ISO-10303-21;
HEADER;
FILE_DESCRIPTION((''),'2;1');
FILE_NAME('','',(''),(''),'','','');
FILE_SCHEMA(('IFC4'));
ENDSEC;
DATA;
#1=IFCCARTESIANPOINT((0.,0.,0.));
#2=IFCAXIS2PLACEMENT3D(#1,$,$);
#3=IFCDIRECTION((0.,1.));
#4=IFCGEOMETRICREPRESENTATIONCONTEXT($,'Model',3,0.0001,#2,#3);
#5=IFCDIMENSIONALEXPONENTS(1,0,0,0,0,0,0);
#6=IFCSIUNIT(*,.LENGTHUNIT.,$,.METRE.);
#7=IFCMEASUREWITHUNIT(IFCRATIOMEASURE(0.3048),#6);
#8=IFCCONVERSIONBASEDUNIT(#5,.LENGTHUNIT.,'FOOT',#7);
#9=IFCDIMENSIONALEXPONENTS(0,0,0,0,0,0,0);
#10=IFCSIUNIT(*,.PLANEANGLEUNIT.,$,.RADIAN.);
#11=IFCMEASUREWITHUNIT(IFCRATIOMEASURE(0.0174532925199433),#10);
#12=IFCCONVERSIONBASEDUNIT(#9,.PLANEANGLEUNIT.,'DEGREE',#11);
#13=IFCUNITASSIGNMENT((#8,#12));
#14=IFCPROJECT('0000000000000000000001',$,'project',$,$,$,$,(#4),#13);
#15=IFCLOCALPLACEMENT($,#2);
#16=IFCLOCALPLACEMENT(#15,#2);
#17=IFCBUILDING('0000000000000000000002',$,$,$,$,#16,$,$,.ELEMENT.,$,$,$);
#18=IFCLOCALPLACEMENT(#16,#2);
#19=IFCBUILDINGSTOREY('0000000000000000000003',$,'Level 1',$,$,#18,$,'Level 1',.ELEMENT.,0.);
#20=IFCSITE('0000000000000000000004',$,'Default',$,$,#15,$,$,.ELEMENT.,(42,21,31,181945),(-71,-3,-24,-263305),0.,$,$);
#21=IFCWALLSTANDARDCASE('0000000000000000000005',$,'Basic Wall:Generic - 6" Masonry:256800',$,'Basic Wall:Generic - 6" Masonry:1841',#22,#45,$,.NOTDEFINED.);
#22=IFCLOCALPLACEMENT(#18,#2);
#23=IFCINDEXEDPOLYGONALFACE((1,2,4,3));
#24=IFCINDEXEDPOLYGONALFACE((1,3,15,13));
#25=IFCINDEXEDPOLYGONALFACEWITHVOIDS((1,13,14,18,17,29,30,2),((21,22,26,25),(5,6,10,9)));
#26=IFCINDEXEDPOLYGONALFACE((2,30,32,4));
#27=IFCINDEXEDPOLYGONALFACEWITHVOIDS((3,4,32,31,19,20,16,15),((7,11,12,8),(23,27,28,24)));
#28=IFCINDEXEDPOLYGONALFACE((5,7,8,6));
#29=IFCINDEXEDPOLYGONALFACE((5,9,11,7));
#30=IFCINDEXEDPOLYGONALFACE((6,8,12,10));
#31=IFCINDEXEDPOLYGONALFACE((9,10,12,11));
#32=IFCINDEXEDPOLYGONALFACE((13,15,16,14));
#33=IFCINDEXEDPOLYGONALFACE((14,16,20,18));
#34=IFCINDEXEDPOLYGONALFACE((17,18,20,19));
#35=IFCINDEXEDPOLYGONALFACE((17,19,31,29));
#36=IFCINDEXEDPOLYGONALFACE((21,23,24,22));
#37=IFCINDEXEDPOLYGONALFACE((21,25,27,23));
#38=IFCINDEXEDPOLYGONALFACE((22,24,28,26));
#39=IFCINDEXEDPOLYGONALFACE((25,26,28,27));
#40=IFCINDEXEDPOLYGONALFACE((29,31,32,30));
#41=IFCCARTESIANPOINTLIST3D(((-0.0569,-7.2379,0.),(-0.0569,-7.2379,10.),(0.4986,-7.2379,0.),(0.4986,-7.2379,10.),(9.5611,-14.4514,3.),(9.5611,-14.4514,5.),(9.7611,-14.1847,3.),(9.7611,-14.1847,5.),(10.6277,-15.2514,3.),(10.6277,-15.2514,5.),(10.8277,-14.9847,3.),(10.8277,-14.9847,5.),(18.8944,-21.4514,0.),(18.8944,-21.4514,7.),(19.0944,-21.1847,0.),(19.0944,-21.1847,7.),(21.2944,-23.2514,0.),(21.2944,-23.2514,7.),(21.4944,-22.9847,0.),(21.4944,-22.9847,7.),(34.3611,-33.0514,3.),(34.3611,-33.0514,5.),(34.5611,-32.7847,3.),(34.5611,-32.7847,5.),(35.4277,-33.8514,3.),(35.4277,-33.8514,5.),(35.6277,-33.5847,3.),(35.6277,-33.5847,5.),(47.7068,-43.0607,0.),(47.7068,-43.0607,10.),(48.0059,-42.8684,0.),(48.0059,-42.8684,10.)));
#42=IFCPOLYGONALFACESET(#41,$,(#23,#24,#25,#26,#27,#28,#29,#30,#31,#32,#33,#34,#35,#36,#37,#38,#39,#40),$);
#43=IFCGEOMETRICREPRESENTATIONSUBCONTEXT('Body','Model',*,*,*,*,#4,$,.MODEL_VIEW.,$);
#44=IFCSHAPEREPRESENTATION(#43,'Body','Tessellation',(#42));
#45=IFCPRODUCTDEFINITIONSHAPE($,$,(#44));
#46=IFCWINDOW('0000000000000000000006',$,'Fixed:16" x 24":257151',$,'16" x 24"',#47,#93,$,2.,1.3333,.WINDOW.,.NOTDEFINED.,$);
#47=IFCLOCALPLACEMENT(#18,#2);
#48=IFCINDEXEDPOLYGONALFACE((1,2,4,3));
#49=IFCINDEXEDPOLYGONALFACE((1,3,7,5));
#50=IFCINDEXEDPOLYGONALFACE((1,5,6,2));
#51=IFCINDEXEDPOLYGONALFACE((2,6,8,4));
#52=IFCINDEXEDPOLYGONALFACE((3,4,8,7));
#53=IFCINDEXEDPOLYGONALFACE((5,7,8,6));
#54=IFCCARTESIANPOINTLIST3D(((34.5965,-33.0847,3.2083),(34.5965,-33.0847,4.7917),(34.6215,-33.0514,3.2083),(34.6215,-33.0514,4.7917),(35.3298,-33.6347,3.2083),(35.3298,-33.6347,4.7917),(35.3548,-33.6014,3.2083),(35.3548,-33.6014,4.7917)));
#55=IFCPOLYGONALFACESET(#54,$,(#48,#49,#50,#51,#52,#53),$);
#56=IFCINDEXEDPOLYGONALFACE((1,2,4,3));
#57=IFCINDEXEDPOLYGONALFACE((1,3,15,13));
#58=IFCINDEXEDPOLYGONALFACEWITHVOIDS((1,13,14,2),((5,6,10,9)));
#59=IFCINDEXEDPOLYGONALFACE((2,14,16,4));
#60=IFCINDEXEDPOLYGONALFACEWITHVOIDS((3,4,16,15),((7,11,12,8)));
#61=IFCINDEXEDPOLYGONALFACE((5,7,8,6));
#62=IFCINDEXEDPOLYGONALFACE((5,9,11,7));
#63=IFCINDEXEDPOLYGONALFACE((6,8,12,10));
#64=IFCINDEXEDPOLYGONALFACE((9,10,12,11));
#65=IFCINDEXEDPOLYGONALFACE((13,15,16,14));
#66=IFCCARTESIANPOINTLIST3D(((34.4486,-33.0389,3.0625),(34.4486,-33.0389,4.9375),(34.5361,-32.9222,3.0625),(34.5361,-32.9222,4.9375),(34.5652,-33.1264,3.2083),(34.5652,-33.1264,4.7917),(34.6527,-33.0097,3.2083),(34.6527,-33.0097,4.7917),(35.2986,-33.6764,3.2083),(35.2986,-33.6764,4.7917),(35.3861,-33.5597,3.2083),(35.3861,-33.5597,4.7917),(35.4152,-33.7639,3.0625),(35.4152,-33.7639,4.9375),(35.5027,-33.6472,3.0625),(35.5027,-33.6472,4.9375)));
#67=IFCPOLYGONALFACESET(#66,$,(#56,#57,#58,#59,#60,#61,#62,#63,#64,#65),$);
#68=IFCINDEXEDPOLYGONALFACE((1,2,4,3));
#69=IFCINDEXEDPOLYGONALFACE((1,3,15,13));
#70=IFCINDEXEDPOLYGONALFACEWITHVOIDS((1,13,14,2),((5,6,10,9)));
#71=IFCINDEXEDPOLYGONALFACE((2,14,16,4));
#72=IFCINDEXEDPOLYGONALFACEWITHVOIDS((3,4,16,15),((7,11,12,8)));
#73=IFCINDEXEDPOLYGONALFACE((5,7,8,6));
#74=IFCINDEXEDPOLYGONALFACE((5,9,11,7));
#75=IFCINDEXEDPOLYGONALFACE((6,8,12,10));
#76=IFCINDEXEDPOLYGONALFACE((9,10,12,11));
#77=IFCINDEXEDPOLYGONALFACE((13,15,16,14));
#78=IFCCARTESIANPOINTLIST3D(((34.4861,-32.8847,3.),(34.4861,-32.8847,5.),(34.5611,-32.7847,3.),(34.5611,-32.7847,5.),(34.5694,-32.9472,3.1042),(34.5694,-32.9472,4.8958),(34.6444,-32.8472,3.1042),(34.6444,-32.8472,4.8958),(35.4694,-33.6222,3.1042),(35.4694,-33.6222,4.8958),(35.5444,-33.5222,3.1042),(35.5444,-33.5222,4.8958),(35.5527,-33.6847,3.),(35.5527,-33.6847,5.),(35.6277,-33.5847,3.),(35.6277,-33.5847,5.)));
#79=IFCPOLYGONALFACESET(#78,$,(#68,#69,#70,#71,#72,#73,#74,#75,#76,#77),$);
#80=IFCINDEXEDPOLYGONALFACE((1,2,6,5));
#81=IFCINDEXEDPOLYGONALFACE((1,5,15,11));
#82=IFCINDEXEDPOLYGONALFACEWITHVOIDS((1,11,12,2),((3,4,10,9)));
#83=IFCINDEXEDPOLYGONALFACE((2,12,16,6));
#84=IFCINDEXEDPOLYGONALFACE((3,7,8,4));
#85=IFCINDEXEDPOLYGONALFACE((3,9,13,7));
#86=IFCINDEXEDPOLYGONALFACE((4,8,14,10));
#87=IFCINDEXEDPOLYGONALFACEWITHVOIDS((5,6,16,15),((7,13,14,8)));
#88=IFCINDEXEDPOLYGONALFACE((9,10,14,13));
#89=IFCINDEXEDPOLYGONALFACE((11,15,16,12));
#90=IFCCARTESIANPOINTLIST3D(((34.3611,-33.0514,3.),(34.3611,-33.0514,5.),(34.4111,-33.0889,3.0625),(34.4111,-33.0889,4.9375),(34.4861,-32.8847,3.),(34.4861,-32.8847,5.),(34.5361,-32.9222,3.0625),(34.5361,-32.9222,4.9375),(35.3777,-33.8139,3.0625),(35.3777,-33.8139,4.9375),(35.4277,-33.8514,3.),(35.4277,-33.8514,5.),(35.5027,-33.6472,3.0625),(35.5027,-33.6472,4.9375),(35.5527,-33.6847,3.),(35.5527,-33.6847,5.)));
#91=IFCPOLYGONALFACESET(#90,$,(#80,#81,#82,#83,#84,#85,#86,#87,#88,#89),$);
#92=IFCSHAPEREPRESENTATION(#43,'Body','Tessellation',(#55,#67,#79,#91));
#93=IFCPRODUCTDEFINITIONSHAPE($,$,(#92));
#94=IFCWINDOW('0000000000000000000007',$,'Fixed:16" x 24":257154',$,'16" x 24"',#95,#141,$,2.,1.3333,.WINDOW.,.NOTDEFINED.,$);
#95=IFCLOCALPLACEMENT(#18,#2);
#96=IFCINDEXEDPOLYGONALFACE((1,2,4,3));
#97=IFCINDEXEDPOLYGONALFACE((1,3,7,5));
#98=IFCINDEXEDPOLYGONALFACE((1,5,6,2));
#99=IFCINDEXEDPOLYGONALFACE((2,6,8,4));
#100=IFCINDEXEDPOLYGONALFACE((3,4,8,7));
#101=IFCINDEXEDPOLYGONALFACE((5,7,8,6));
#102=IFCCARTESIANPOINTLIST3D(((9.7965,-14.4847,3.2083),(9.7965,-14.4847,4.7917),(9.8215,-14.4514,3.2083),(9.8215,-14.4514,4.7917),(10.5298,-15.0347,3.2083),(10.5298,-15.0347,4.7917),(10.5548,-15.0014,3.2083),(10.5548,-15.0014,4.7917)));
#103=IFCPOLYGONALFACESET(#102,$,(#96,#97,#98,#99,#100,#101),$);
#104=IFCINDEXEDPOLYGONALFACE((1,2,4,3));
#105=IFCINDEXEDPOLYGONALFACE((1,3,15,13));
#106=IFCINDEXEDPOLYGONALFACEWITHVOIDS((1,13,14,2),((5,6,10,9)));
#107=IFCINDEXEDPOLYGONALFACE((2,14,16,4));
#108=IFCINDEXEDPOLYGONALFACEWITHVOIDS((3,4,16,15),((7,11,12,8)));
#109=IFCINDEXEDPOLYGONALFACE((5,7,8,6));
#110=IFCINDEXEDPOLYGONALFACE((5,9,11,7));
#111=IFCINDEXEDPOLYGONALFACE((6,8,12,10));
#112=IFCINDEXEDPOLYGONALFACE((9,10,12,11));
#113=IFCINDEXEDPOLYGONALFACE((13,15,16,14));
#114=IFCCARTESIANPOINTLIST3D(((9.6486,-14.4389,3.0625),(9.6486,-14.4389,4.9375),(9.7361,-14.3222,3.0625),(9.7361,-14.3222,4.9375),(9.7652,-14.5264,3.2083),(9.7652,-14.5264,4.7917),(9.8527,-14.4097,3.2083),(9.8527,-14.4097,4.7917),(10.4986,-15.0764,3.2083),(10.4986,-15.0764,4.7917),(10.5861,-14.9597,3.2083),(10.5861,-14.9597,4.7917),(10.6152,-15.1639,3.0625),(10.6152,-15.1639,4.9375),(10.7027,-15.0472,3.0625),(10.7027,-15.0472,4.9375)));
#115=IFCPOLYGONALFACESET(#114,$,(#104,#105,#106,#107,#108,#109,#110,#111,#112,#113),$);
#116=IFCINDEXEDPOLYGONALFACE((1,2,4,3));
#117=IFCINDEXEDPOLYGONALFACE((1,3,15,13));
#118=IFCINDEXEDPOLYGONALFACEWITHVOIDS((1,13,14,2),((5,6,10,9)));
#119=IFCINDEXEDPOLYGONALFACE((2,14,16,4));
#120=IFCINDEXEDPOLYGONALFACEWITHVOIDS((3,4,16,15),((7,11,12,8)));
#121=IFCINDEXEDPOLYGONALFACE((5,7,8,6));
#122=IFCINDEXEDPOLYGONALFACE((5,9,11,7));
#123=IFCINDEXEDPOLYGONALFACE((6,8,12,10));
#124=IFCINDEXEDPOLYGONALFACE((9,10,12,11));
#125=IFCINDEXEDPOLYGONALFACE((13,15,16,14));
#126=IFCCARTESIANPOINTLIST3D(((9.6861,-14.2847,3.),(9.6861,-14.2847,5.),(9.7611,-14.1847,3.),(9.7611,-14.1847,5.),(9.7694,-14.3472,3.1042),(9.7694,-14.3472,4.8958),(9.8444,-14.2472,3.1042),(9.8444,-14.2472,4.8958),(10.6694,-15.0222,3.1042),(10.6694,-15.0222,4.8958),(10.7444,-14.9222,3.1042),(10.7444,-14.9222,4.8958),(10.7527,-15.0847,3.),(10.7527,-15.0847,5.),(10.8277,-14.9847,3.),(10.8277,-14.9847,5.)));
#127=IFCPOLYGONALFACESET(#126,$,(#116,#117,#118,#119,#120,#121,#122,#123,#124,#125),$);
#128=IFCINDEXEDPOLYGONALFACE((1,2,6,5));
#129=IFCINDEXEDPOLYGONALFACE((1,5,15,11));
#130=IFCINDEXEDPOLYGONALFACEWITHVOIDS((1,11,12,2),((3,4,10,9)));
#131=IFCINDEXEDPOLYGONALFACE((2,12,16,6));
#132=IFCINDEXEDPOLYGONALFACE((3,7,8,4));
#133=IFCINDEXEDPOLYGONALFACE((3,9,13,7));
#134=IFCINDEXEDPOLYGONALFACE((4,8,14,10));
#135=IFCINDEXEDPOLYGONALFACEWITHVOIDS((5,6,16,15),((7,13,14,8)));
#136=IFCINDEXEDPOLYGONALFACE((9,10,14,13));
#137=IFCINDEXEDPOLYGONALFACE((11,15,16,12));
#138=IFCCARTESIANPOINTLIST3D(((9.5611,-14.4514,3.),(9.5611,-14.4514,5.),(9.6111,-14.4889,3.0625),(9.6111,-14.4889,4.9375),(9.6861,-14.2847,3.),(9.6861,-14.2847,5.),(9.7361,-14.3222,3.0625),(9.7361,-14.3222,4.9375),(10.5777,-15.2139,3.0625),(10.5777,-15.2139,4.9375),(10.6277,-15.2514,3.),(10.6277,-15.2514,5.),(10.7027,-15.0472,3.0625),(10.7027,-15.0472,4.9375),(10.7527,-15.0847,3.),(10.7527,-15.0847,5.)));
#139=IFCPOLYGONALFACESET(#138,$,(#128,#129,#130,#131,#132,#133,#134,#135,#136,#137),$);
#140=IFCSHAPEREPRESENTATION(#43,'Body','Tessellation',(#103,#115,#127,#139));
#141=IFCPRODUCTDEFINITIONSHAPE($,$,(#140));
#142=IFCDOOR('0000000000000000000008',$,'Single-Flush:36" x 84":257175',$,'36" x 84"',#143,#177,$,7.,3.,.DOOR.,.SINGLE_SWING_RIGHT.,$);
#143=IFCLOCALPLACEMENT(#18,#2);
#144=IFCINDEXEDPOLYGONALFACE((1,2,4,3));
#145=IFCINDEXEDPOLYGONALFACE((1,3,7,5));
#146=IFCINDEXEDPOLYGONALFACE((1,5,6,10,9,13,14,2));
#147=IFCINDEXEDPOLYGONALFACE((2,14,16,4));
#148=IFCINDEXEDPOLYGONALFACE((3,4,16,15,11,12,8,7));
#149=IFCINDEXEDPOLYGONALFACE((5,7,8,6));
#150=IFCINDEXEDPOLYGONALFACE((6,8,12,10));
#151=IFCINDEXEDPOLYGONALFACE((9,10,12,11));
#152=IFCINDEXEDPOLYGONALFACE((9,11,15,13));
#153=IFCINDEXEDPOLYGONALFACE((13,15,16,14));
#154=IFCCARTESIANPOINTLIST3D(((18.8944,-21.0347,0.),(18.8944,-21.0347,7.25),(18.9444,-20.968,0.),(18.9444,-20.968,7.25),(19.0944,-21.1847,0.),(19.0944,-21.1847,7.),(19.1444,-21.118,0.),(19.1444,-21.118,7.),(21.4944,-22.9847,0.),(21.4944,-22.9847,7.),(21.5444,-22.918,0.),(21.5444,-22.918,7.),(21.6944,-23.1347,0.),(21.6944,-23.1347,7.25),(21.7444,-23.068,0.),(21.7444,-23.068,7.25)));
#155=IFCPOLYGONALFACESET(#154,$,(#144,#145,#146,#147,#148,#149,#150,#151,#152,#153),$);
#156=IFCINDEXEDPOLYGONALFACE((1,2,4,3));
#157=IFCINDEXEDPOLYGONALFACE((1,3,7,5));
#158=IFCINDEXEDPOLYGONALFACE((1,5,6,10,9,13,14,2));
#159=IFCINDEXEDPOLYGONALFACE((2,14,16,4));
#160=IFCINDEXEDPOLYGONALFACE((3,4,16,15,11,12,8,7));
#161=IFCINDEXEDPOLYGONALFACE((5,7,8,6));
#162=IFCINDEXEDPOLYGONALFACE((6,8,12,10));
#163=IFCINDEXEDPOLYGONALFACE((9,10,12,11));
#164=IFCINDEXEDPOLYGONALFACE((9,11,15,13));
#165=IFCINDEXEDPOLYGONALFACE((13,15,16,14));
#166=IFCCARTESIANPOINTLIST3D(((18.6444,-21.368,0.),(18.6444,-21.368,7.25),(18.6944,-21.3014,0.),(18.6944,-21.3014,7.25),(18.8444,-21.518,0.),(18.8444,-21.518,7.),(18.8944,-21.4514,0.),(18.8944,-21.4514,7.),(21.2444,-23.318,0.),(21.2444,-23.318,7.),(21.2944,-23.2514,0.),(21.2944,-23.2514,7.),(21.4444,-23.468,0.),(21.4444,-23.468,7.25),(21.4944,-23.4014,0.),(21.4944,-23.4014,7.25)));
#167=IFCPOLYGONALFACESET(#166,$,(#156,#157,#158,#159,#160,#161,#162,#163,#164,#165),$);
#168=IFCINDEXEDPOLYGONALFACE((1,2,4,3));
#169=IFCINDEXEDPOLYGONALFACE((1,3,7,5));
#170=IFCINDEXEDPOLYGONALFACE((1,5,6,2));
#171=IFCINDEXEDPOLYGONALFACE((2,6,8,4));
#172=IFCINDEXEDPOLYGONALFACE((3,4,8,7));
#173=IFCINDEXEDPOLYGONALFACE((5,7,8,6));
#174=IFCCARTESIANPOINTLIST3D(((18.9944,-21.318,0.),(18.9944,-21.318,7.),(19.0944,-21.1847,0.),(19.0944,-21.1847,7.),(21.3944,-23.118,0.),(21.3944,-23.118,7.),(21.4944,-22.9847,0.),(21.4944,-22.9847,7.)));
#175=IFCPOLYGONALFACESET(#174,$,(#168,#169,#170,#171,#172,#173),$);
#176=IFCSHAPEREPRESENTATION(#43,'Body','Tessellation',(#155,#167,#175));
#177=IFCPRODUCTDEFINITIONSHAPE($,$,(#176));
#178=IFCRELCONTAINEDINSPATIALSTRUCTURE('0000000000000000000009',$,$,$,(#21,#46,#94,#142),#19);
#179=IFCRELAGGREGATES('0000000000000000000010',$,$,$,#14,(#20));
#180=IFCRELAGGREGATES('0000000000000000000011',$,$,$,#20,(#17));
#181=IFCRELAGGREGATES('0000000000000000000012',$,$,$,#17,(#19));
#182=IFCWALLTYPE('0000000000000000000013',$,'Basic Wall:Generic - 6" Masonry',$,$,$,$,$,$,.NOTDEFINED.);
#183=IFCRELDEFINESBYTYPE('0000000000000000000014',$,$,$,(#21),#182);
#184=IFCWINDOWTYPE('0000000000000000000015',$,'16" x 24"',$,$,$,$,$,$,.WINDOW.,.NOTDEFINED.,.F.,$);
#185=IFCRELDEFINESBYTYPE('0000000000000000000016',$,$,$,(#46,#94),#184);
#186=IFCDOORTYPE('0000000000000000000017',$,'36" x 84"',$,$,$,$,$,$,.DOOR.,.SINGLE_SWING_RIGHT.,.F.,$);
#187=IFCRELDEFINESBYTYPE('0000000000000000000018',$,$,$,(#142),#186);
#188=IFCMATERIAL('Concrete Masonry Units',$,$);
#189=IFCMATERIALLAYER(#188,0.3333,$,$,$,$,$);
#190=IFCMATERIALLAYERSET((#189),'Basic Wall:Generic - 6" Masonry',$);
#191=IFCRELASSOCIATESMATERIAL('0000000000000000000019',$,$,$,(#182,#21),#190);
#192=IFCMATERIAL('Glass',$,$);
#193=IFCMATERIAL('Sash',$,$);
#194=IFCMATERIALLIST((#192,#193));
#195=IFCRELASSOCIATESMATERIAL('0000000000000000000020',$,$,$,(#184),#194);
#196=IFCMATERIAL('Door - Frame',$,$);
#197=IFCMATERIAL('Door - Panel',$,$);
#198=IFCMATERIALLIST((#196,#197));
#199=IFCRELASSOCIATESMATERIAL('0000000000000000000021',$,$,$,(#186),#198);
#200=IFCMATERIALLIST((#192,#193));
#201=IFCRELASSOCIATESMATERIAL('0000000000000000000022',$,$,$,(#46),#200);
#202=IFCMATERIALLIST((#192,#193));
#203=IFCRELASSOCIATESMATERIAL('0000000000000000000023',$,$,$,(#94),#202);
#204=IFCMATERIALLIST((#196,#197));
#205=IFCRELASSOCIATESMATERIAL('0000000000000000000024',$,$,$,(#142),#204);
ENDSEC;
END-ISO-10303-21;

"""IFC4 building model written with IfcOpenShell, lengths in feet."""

from ifc_helpers import new_model, entity, si_unit, converted_unit, direction, frame, frame_2d, origin, origin_2d_with_axis, place, context, subcontext, project, spatial, polyline, rectangle, outline, extrude, source, transform, mapped, material, material_list, layer, layer_set, layer_usage, type_object, type_shapes, element, fill, save


model = new_model("IFC4")

# Units and contexts
model_context = context("Model", 3, precision=0.0001, world=origin(), true_north=direction((0.0, 1.0)))
body_context = subcontext(model_context, "Body", "Model", "MODEL_VIEW")
ifc_project = project(units=[converted_unit("LENGTHUNIT", "FOOT", entity("IfcRatioMeasure", 0.3048), si_unit("LENGTHUNIT", "METRE"), dimensions=[1, 0, 0, 0, 0, 0, 0]), converted_unit("PLANEANGLEUNIT", "DEGREE", entity("IfcRatioMeasure", 0.0174532925199433), si_unit("PLANEANGLEUNIT", "RADIAN"), dimensions=[0, 0, 0, 0, 0, 0, 0])], contexts=[model_context])

# Site, building, storey
site_placement = place(None, origin())
site = spatial("IfcSite", under=ifc_project, at=site_placement, Name="Default", CompositionType="ELEMENT", RefLatitude=(42, 21, 31, 181945), RefLongitude=(-71, -3, -24, -263305), RefElevation=0.0)
building_placement = place(site_placement, origin())
building = spatial("IfcBuilding", under=site, at=building_placement, CompositionType="ELEMENT")
storey_placement = place(building_placement, origin())
storey = spatial("IfcBuildingStorey", under=building, at=storey_placement, Name="Level 1", LongName="Level 1", CompositionType="ELEMENT", Elevation=0.0)

# Shared definitions
ifc_material_1 = material(Name="Concrete Masonry Units")
ifc_layer = layer(ifc_material_1, 0.3333)
ifc_layer_set = layer_set([ifc_layer], Name="Basic Wall:Generic - 6\" Masonry")
wall_type = type_object("IfcWallType", Name="Basic Wall:Generic - 6\" Masonry", PredefinedType="NOTDEFINED", material=ifc_layer_set)
ifc_material_2 = material(Name="Glass")
ifc_material_3 = material(Name="Sash")
ifc_material_list_1 = material_list([ifc_material_2, ifc_material_3])
window_type = type_object("IfcWindowType", Name="16\" x 24\"", ParameterTakesPrecedence=False, PartitioningType="NOTDEFINED", PredefinedType="WINDOW", material=ifc_material_list_1)
shared_shape_1 = source(origin(), body_context, "Body", "SweptSolid", [
    extrude(rectangle(XDim=0.0417, YDim=0.9167, at=origin_2d_with_axis()), frame((0.6667, 0.1979, 0.2083), z_axis=(0.0, 0.0, 1.0), x_axis=(0.0, 1.0, 0.0)), (0.0, 0.0, 1.0), 1.5833),
    extrude(outline(polyline([(-0.6042, -0.9375), (0.6042, -0.9375), (0.6042, 0.9375), (-0.6042, 0.9375), (-0.6042, -0.9375)]), holes=[polyline([(-0.4583, -0.7917), (-0.4583, 0.7917), (0.4583, 0.7917), (0.4583, -0.7917), (-0.4583, -0.7917)])]), frame((0.6667, 0.125, 1.0), z_axis=(0.0, 1.0, 0.0), x_axis=(1.0, 0.0, 0.0)), (0.0, 0.0, 1.0), 0.1458),
    extrude(outline(polyline([(-0.6667, -1.0), (0.6667, -1.0), (0.6667, 1.0), (-0.6667, 1.0), (-0.6667, -1.0)]), holes=[polyline([(-0.5625, -0.8958), (-0.5625, 0.8958), (0.5625, 0.8958), (0.5625, -0.8958), (-0.5625, -0.8958)])]), frame((0.6667, 0.0, 1.0), z_axis=(0.0, 1.0, 0.0), x_axis=(1.0, 0.0, 0.0)), (0.0, 0.0, 1.0), 0.125),
    extrude(outline(polyline([(-1.0, -0.6667), (1.0, -0.6667), (1.0, 0.6667), (-1.0, 0.6667), (-1.0, -0.6667)]), holes=[polyline([(-0.9375, -0.6042), (-0.9375, 0.6042), (0.9375, 0.6042), (0.9375, -0.6042), (-0.9375, -0.6042)])]), frame((0.6667, 0.125, 1.0), z_axis=(0.0, 1.0, 0.0), x_axis=(0.0, 0.0, -1.0)), (0.0, 0.0, 1.0), 0.2083),
])
type_shapes(window_type, [shared_shape_1])
ifc_material_4 = material(Name="Door - Frame")
ifc_material_5 = material(Name="Door - Panel")
ifc_material_list_2 = material_list([ifc_material_4, ifc_material_5])
door_type = type_object("IfcDoorType", Name="36\" x 84\"", OperationType="SINGLE_SWING_RIGHT", ParameterTakesPrecedence=False, PredefinedType="DOOR", material=ifc_material_list_2)
shared_shape_2 = source(origin(), body_context, "Body", "SweptSolid", [
    extrude(outline(polyline([(-1.75, -3.6875), (1.75, -3.6875), (1.75, 3.5625), (1.5, 3.5625), (1.5, -3.4375), (-1.5, -3.4375), (-1.5, 3.5625), (-1.75, 3.5625), (-1.75, -3.6875)])), frame((1.5, 0.3333, 3.5625), z_axis=(0.0, 1.0, 0.0), x_axis=(1.0, 0.0, 0.0)), (0.0, 0.0, 1.0), 0.0833),
    extrude(outline(polyline([(-3.6875, -1.75), (3.5625, -1.75), (3.5625, -1.5), (-3.4375, -1.5), (-3.4375, 1.5), (3.5625, 1.5), (3.5625, 1.75), (-3.6875, 1.75), (-3.6875, -1.75)])), frame((1.5, -0.0833, 3.5625), z_axis=(0.0, 1.0, 0.0), x_axis=(0.0, 0.0, -1.0)), (0.0, 0.0, 1.0), 0.0833),
    extrude(rectangle(XDim=0.1667, YDim=3.0, at=frame_2d((0.0, 0.0), x_axis=(1.0, 0.0))), frame((1.5, 0.25, 0.0), z_axis=(0.0, 0.0, 1.0), x_axis=(0.0, 1.0, 0.0)), (0.0, 0.0, 1.0), 7.0),
])
type_shapes(door_type, [shared_shape_2])

# Wall, openings, windows, door
ifc_layer_usage_1 = layer_usage(ifc_layer_set, "AXIS2", "NEGATIVE", 0.1667)
wall_1_placement = place(storey_placement, frame((47.9059, -43.0017, 0.0), z_axis=(0.0, 0.0, 1.0), x_axis=(-0.8, 0.6, 0.0)))
wall_1 = element("IfcWallStandardCase", 1, at=wall_1_placement, inside=storey, type_object=wall_type, material=ifc_layer_usage_1, Name="Basic Wall:Generic - 6\" Masonry:256800", ObjectType="Basic Wall:Generic - 6\" Masonry:1841", PredefinedType="NOTDEFINED", context=body_context, shape_type="SweptSolid", body=[
    extrude(outline(polyline([(0.0, -0.1667), (59.3842, -0.1667), (59.8286, 0.1667), (0.1239, 0.1667), (0.0, -0.1667)])), origin(), (0.0, 0.0, 1.0), 10.0),
])
opening_1_placement = place(wall_1_placement, frame((36.1394, 0.1667, 0.0)))
opening_1 = element("IfcOpeningElement", 2, at=opening_1_placement, cuts=wall_1, ObjectType="Opening", PredefinedType="OPENING", context=body_context, shape_type="SweptSolid", body=[
    extrude(rectangle(XDim=3.0, YDim=7.0, at=frame_2d((3.5, 1.5), x_axis=(0.0, 1.0))), frame((0.0, 0.0, 0.0), z_axis=(0.0, -1.0, 0.0), x_axis=(0.0, 0.0, 1.0)), (0.0, 0.0, 1.0), 0.3333),
])
opening_2_placement = place(wall_1_placement, frame((15.4728, -0.1667, 3.0)))
opening_2 = element("IfcOpeningElement", 3, at=opening_2_placement, cuts=wall_1, ObjectType="Opening", PredefinedType="OPENING", context=body_context, shape_type="SweptSolid", body=[
    extrude(rectangle(XDim=2.0, YDim=1.3333, at=frame_2d((1.0, 0.6667), x_axis=(-1.0, 0.0))), frame((0.0, 0.0, 0.0), z_axis=(0.0, 1.0, 0.0), x_axis=(0.0, 0.0, 1.0)), (0.0, 0.0, 1.0), 0.3333),
])
opening_3_placement = place(wall_1_placement, frame((46.4728, -0.1667, 3.0)))
opening_3 = element("IfcOpeningElement", 4, at=opening_3_placement, cuts=wall_1, ObjectType="Opening", PredefinedType="OPENING", context=body_context, shape_type="SweptSolid", body=[
    extrude(rectangle(XDim=2.0, YDim=1.3333, at=frame_2d((1.0, 0.6667), x_axis=(-1.0, 0.0))), frame((0.0, 0.0, 0.0), z_axis=(0.0, 1.0, 0.0), x_axis=(0.0, 0.0, 1.0)), (0.0, 0.0, 1.0), 0.3333),
])
ifc_material_list_3 = material_list([ifc_material_2, ifc_material_3])
window_1_placement = place(opening_2_placement, origin())
window_1 = element("IfcWindow", 5, at=window_1_placement, inside=storey, type_object=window_type, material=ifc_material_list_3, Name="Fixed:16\" x 24\":257151", ObjectType="16\" x 24\"", OverallHeight=2.0, OverallWidth=1.3333, PartitioningType="NOTDEFINED", PredefinedType="WINDOW", context=body_context, shape_type="MappedRepresentation", body=[
    mapped(shared_shape_1, transform((0.0, 0.0, 0.0), scale=1.0)),
])
fill(opening_2, window_1)
ifc_material_list_4 = material_list([ifc_material_2, ifc_material_3])
window_2_placement = place(opening_3_placement, origin())
window_2 = element("IfcWindow", 6, at=window_2_placement, inside=storey, type_object=window_type, material=ifc_material_list_4, Name="Fixed:16\" x 24\":257154", ObjectType="16\" x 24\"", OverallHeight=2.0, OverallWidth=1.3333, PartitioningType="NOTDEFINED", PredefinedType="WINDOW", context=body_context, shape_type="MappedRepresentation", body=[
    mapped(shared_shape_1, transform((0.0, 0.0, 0.0), scale=1.0)),
])
fill(opening_3, window_2)
ifc_material_list_5 = material_list([ifc_material_4, ifc_material_5])
door_1_placement = place(opening_1_placement, frame((0.0, 0.0, 0.0), z_axis=(0.0, 0.0, 1.0), x_axis=(-1.0, 0.0, 0.0)))
door_1 = element("IfcDoor", 7, at=door_1_placement, inside=storey, type_object=door_type, material=ifc_material_list_5, Name="Single-Flush:36\" x 84\":257175", ObjectType="36\" x 84\"", OperationType="SINGLE_SWING_RIGHT", OverallHeight=7.0, OverallWidth=3.0, PredefinedType="DOOR", context=body_context, shape_type="MappedRepresentation", body=[
    mapped(shared_shape_2, transform((0.0, 0.0, 0.0), scale=1.0)),
])
fill(opening_1, door_1)

save(model, "model.ifc")
